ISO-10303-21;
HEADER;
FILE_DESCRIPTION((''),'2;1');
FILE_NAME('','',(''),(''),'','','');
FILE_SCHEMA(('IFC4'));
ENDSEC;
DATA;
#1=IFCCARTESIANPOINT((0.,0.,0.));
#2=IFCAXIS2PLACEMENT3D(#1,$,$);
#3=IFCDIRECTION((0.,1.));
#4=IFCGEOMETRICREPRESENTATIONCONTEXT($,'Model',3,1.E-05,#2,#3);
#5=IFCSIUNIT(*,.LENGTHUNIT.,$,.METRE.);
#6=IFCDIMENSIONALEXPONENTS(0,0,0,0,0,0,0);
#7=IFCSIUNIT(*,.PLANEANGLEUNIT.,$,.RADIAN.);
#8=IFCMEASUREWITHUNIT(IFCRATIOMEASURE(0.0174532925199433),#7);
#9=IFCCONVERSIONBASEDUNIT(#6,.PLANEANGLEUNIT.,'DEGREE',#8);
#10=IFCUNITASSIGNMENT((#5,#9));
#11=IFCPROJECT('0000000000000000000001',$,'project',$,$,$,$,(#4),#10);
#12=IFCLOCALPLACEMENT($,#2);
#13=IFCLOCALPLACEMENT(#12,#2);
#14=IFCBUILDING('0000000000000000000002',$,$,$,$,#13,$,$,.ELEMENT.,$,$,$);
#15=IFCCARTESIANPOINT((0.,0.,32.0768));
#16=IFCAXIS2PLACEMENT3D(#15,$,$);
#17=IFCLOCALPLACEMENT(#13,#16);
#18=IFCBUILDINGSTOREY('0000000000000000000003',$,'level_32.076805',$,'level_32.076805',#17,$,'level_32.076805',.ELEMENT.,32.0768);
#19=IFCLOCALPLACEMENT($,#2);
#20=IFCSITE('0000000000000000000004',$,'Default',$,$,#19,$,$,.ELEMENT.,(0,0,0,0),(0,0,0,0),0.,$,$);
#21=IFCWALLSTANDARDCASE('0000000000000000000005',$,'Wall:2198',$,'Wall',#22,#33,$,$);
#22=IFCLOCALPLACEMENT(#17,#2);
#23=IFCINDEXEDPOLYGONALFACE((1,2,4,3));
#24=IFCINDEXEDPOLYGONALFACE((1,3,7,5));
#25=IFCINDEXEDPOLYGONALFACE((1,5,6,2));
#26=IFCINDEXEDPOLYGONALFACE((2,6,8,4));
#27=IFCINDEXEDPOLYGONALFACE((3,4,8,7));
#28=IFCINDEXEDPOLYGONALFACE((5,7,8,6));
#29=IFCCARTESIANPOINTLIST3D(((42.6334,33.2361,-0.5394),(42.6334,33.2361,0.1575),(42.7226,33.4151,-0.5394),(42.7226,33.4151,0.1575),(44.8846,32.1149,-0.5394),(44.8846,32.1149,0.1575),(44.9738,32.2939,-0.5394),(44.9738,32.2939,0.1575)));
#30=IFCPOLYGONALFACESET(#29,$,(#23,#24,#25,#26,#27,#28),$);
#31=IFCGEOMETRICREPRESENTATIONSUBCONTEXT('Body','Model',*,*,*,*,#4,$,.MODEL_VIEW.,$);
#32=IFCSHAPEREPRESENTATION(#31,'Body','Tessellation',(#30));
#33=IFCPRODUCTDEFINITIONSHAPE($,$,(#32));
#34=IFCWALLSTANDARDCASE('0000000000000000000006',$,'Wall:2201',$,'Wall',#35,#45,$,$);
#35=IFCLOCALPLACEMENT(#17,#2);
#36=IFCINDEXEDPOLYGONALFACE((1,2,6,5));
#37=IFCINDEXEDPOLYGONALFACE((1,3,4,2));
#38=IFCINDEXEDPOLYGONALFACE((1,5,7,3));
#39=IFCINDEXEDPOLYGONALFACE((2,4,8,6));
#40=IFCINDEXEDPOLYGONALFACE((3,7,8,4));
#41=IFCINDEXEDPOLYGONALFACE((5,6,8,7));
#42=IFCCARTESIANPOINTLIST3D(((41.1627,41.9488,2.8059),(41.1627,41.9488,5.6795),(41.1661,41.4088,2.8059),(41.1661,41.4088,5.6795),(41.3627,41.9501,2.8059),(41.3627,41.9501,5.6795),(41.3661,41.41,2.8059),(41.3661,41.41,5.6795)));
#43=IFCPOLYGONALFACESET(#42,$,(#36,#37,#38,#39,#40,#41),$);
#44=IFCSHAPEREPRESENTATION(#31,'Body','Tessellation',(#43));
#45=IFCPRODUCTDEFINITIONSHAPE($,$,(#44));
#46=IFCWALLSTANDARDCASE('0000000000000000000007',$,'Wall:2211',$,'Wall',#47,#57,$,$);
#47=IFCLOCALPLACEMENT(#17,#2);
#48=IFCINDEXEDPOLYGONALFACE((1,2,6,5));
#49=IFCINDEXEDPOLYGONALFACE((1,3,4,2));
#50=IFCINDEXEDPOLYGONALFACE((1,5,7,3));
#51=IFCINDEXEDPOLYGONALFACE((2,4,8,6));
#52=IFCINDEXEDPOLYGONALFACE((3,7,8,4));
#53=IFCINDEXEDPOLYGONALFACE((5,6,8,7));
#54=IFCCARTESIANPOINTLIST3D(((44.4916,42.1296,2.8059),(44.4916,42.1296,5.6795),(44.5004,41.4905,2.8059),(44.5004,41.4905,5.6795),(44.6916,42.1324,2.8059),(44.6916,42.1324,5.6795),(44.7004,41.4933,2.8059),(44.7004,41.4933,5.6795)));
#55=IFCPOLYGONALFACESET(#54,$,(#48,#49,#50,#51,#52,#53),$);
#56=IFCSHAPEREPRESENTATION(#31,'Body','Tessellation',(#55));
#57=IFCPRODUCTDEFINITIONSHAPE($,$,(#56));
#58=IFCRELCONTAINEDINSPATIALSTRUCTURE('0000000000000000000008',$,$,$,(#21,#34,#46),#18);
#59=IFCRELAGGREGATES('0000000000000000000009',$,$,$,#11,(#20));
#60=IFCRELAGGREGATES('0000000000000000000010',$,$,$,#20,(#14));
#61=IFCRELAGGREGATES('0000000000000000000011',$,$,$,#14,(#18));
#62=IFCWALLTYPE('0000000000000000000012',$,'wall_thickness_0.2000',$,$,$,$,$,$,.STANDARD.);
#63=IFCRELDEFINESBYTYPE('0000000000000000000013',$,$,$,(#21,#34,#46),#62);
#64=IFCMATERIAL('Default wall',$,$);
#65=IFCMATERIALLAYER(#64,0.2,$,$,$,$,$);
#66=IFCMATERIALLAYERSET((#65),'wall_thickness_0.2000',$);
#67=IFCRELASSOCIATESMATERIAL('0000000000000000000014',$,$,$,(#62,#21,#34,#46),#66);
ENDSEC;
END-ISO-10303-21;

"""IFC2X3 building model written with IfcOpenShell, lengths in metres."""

from ifc_helpers import new_model, entity, si_unit, converted_unit, direction, frame, origin, place, context, subcontext, project, spatial, polyline, outline, extrude, material, layer, layer_set, layer_usage, type_object, element, save


model = new_model("IFC2X3")

# Units and contexts
model_context = context("Model", 3, precision=1e-05, world=origin(), true_north=direction((0.0, 1.0)))
body_context = subcontext(model_context, "Body", "Model", "MODEL_VIEW")
ifc_project = project(units=[si_unit("LENGTHUNIT", "METRE"), converted_unit("PLANEANGLEUNIT", "DEGREE", entity("IfcRatioMeasure", 0.0174532925199433), si_unit("PLANEANGLEUNIT", "RADIAN"), dimensions=[0, 0, 0, 0, 0, 0, 0])], contexts=[model_context])

# Site, building, storey
site_placement = place(None, origin())
site = spatial("IfcSite", under=ifc_project, at=site_placement, Name="Default", CompositionType="ELEMENT", RefLatitude=(0, 0, 0, 0), RefLongitude=(0, 0, 0, 0), RefElevation=0.0)
placement_1 = place(None, origin())
building_placement = place(placement_1, origin())
building = spatial("IfcBuilding", under=site, at=building_placement, CompositionType="ELEMENT")
storey_placement = place(building_placement, frame((0.0, 0.0, 32.0768)))
storey = spatial("IfcBuildingStorey", under=building, at=storey_placement, Name="level_32.076805", ObjectType="level_32.076805", LongName="level_32.076805", CompositionType="ELEMENT", Elevation=32.0768)

# Shared definitions
ifc_material_1 = material(Name="Default wall")
ifc_layer = layer(ifc_material_1, 0.2)
ifc_layer_set = layer_set([ifc_layer], Name="wall_thickness_0.2000")
ifc_layer_usage = layer_usage(ifc_layer_set, "AXIS2", "POSITIVE", -0.1)
wall_type = type_object("IfcWallType", Name="wall_thickness_0.2000", PredefinedType="STANDARD", material=ifc_layer_set)

# Walls
placement_2 = place(building_placement, frame((0.0, 0.0, 31.5374)))
wall_1_placement = place(placement_2, frame((42.678, 33.3256, 0.0), z_axis=(0.0, 0.0, 1.0), x_axis=(0.895127, -0.44581, 0.0)))
element("IfcWallStandardCase", 1, at=wall_1_placement, inside=storey, type_object=wall_type, material=ifc_layer_usage, Name="Wall:2198", ObjectType="Wall", context=body_context, shape_type="SweptSolid", body=[
    extrude(outline(polyline([(2.515, -0.1), (2.515, 0.1), (0.0, 0.1), (0.0, -0.1), (2.515, -0.1)])), origin(), (0.0, 0.0, 1.0), 0.6969),
])
placement_3 = place(building_placement, frame((0.0, 0.0, 34.8827)))
wall_2_placement = place(placement_3, frame((41.2627, 41.9495, 0.0), z_axis=(0.0, 0.0, 1.0), x_axis=(0.006335, -0.99998, 0.0)))
element("IfcWallStandardCase", 2, at=wall_2_placement, inside=storey, type_object=wall_type, material=ifc_layer_usage, Name="Wall:2201", ObjectType="Wall", context=body_context, shape_type="SweptSolid", body=[
    extrude(outline(polyline([(0.5401, -0.1), (0.5401, 0.1), (0.0, 0.1), (0.0, -0.1), (0.5401, -0.1)])), origin(), (0.0, 0.0, 1.0), 2.8737),
])
placement_4 = place(building_placement, frame((0.0, 0.0, 34.8827)))
wall_3_placement = place(placement_4, frame((44.6004, 41.4919, 0.0), z_axis=(0.0, 0.0, 1.0), x_axis=(-0.013733, 0.999906, 0.0)))
element("IfcWallStandardCase", 3, at=wall_3_placement, inside=storey, type_object=wall_type, material=ifc_layer_usage, Name="Wall:2211", ObjectType="Wall", context=body_context, shape_type="SweptSolid", body=[
    extrude(outline(polyline([(0.6391, -0.1), (0.6391, 0.1), (0.0, 0.1), (0.0, -0.1), (0.6391, -0.1)])), origin(), (0.0, 0.0, 1.0), 2.8737),
])

save(model, "model.ifc")
